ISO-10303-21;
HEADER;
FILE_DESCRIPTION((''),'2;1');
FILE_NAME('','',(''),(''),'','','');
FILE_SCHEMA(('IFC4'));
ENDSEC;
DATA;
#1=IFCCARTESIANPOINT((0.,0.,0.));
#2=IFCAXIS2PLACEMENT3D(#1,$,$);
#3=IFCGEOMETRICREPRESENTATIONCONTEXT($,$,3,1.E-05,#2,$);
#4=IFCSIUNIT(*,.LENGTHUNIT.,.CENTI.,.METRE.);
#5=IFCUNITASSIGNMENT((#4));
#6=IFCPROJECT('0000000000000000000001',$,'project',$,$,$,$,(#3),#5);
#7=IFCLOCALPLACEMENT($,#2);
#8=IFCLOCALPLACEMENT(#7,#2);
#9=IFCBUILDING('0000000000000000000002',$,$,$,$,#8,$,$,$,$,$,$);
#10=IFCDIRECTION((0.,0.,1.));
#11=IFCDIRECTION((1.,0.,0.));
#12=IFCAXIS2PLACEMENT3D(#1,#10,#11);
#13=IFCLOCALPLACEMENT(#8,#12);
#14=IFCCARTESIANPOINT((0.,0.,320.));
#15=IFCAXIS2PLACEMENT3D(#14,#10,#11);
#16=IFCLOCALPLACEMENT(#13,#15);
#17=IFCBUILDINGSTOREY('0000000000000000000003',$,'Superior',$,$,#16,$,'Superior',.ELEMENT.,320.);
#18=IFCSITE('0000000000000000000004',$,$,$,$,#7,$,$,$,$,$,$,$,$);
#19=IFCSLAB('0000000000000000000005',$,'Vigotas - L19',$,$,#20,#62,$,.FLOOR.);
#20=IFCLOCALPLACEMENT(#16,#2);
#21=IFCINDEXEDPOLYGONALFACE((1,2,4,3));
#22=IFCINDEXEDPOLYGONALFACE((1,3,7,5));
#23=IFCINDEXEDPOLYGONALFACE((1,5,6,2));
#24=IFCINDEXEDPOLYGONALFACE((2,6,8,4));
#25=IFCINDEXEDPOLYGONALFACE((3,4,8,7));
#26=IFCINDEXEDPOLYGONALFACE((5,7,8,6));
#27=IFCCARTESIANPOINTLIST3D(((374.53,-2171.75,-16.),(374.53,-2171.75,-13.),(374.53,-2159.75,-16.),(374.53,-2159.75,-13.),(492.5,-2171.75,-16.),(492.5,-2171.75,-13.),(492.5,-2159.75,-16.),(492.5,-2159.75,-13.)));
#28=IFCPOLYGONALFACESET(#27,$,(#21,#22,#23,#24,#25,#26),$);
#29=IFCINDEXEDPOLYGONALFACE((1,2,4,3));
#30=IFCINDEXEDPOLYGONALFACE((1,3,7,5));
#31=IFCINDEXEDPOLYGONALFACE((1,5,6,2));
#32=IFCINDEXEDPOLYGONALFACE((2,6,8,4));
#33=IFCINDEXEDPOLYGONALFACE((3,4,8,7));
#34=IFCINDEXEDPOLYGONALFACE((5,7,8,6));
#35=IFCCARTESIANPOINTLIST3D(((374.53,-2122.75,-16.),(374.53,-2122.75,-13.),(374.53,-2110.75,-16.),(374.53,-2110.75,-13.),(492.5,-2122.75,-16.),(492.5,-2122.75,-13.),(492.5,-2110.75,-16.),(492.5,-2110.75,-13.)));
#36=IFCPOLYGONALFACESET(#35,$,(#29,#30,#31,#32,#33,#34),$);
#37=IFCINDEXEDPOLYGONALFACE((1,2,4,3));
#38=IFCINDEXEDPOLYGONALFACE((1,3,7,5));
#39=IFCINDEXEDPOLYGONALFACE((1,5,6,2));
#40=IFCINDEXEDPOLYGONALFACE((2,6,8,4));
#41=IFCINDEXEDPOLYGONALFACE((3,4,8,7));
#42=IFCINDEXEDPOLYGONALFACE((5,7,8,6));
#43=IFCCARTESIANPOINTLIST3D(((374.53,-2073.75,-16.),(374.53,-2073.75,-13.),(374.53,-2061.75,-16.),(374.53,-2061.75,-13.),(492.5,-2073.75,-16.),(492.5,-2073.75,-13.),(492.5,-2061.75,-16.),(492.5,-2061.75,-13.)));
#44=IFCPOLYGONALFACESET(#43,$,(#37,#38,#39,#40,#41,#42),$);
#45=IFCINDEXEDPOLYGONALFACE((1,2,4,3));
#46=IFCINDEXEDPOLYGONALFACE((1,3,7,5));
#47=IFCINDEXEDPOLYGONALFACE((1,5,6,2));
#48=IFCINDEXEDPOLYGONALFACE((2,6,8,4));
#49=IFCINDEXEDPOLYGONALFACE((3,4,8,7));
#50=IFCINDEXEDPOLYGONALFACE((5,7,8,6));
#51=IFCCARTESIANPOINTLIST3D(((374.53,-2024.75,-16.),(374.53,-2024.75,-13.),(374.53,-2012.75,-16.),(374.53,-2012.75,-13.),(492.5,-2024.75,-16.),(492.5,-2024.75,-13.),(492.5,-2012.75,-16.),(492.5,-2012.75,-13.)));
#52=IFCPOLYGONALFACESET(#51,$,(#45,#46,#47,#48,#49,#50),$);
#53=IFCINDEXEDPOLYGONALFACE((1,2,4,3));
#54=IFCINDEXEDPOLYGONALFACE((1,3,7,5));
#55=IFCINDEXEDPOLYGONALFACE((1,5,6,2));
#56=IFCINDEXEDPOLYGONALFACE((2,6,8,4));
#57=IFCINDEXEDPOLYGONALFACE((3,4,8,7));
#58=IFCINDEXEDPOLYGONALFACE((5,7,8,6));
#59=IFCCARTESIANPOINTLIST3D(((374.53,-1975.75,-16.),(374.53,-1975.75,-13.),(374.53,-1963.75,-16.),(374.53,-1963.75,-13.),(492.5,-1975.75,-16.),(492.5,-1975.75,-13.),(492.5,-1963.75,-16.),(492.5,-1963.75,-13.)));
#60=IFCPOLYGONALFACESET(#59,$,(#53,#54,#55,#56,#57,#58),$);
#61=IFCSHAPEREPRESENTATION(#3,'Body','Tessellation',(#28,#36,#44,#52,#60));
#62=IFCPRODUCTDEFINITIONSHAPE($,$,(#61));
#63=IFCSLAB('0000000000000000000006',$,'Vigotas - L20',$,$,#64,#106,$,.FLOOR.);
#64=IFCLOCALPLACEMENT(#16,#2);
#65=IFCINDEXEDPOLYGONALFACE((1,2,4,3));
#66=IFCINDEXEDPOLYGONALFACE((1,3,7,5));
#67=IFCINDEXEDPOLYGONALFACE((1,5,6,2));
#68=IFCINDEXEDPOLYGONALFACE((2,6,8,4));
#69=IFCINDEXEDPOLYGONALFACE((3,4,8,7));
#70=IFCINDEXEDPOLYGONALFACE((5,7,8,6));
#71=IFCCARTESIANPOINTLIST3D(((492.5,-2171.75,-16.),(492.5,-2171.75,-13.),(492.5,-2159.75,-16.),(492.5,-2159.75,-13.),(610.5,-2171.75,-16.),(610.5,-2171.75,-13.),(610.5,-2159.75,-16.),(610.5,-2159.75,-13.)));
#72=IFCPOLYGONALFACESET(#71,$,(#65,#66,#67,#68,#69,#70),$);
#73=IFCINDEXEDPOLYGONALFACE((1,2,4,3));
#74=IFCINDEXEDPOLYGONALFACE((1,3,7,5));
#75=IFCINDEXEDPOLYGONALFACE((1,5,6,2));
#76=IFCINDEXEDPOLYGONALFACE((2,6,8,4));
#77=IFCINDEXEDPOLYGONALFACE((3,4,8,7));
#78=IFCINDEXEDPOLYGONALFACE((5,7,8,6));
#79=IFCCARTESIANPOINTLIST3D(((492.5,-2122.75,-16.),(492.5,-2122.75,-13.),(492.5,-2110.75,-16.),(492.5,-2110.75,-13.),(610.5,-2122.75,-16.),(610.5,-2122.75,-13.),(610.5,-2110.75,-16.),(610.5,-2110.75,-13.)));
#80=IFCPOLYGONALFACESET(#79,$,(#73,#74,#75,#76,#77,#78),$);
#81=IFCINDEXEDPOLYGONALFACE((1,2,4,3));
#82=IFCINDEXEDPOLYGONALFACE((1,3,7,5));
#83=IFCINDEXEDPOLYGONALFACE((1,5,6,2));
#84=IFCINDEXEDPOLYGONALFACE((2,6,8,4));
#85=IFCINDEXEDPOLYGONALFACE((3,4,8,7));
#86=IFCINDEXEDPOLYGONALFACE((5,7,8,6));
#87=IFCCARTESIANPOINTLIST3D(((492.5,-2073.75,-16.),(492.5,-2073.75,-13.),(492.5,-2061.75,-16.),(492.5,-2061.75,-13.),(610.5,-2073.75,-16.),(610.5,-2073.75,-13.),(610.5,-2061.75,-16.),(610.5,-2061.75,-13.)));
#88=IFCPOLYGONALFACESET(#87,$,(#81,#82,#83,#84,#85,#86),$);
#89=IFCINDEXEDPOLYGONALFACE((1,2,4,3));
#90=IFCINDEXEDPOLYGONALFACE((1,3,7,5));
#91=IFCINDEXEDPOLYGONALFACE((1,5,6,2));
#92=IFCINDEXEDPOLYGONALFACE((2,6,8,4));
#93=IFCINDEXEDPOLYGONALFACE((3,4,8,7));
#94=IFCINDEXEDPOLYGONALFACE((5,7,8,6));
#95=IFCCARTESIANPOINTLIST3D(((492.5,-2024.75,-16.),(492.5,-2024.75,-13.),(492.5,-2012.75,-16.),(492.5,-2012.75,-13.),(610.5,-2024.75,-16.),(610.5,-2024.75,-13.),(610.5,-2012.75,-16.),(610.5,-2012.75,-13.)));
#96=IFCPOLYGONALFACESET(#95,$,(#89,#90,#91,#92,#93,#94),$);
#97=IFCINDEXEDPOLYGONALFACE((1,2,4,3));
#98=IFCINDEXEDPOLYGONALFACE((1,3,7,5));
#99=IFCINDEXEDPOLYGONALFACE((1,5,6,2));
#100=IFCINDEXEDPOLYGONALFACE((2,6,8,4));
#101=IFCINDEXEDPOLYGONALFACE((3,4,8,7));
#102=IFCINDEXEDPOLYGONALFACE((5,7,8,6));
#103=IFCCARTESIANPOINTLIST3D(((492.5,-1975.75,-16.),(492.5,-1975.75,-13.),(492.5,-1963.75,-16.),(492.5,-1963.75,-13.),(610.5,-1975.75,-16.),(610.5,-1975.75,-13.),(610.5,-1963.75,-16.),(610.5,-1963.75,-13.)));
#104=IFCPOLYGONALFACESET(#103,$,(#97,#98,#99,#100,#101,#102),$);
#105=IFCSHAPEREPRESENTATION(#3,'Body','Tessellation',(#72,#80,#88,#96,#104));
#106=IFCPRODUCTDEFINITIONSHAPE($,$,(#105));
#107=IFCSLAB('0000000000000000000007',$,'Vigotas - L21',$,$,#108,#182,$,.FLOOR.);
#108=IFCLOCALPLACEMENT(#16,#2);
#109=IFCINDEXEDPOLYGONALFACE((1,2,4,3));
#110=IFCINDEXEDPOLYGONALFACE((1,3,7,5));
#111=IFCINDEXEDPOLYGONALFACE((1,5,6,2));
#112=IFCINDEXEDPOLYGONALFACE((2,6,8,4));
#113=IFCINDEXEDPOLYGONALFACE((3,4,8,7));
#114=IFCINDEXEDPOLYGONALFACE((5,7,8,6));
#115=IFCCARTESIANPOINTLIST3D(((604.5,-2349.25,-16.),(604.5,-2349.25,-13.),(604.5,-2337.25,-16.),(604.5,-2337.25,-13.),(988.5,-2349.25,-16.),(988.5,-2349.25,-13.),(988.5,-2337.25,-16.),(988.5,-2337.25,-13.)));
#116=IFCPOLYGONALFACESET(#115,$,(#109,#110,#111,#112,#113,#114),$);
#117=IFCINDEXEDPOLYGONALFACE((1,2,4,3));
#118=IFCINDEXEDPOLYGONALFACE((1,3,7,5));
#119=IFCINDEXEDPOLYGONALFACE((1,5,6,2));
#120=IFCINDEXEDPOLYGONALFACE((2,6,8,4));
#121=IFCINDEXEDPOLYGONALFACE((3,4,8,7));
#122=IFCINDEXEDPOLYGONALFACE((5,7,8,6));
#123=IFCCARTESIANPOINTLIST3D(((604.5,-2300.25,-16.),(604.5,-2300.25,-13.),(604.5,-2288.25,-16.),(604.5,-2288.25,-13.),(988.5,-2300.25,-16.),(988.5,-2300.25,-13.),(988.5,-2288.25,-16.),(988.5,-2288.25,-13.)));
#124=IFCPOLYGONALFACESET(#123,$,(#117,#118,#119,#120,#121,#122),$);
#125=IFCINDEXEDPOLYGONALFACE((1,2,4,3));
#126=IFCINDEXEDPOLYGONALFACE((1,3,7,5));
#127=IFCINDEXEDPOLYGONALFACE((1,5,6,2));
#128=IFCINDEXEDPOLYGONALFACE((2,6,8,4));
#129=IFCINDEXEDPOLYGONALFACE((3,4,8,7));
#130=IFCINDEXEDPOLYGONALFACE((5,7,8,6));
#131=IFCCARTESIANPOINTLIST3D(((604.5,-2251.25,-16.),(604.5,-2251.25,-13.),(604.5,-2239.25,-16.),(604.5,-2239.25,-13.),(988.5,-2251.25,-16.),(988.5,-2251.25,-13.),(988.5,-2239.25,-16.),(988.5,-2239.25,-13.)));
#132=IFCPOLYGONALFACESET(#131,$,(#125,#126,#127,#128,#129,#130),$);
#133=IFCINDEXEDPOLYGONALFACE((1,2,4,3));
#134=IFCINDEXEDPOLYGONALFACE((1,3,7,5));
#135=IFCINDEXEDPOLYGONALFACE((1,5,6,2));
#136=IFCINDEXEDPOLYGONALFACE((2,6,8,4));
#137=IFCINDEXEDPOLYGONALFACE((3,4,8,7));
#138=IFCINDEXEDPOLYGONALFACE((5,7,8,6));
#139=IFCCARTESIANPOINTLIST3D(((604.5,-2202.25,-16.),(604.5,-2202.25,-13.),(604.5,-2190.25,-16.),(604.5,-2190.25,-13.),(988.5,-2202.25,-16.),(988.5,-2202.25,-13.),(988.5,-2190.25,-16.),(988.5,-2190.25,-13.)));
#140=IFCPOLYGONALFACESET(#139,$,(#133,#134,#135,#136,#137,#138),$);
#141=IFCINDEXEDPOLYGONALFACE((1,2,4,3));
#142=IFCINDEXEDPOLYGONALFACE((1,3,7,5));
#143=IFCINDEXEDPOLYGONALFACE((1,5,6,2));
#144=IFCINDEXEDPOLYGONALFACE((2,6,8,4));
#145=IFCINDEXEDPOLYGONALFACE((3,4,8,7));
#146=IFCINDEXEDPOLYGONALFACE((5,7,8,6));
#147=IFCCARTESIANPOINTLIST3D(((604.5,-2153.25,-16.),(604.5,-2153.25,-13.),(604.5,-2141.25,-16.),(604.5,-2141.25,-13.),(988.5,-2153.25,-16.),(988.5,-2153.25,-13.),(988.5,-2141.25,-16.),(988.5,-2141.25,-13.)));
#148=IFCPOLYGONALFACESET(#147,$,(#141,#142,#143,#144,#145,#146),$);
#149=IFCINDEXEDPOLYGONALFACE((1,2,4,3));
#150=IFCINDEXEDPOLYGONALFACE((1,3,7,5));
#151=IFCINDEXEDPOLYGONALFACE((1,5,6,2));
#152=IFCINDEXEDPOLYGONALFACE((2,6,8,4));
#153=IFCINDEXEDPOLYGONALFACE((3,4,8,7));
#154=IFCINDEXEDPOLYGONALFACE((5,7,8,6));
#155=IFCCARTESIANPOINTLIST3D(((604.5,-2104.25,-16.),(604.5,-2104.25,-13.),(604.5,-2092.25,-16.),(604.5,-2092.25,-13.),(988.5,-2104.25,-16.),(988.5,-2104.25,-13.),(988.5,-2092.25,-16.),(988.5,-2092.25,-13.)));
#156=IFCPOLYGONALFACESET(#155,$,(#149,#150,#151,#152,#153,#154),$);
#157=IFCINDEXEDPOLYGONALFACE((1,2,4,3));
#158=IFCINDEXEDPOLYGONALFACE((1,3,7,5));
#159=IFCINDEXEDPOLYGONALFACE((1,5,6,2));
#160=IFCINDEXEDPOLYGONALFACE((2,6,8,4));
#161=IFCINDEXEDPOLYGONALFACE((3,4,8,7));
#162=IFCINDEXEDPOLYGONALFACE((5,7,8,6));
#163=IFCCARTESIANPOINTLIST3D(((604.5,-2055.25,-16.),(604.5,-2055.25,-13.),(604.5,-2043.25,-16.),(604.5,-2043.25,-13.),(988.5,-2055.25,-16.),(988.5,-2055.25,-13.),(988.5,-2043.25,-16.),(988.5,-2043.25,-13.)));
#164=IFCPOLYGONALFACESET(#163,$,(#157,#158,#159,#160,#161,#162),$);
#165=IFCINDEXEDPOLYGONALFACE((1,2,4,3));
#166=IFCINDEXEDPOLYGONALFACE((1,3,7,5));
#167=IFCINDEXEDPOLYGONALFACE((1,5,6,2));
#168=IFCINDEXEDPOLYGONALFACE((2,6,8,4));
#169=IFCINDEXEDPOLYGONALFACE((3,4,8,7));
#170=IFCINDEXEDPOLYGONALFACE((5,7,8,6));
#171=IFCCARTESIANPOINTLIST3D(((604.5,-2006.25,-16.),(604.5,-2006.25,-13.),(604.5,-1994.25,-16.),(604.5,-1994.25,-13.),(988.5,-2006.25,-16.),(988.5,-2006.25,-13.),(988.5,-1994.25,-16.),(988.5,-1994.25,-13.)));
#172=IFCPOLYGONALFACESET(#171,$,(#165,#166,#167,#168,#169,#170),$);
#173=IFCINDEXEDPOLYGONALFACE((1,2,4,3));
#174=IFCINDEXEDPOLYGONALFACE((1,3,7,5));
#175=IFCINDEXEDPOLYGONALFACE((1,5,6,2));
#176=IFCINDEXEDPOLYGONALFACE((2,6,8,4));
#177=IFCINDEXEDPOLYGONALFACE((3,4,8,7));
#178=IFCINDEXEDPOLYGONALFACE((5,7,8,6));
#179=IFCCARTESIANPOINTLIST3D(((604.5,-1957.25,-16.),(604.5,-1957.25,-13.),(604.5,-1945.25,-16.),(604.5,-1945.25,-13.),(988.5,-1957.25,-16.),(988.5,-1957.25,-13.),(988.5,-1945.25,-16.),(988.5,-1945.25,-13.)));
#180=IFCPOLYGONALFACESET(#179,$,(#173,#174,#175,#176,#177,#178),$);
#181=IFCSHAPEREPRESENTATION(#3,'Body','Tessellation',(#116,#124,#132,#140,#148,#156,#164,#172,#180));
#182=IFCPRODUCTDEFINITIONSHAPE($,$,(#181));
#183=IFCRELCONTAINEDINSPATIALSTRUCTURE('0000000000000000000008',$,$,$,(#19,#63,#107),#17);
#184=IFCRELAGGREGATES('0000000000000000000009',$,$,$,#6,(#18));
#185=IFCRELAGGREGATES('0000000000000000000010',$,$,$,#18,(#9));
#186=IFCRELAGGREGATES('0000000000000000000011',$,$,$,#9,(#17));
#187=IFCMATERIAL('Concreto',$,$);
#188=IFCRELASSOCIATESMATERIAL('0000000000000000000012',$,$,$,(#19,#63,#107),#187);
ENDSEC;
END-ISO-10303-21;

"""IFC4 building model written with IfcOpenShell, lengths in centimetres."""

from ifc_helpers import new_model, si_unit, frame, origin, origin_with_axes, place, context, project, spatial, polyline, outline, extrude, material, element, save


model = new_model("IFC4")

# Units and contexts
context_of_model = context(None, 3, precision=1e-05, world=origin())
ifc_project = project(units=[si_unit("LENGTHUNIT", "METRE", prefix="CENTI")], contexts=[context_of_model])

# Site, building, storey
site_placement = place(None, origin())
site = spatial("IfcSite", under=ifc_project, at=site_placement)
building_placement = place(site_placement, origin())
building = spatial("IfcBuilding", under=site, at=building_placement)
placement = place(building_placement, origin_with_axes())
storey_placement = place(placement, frame((0.0, 0.0, 320.0), z_axis=(0.0, 0.0, 1.0), x_axis=(1.0, 0.0, 0.0)))
storey = spatial("IfcBuildingStorey", under=building, at=storey_placement, Name="Superior", LongName="Superior", CompositionType="ELEMENT", Elevation=320.0)

# Shared definitions
ifc_material = material(Name="Concreto")

# Slabs
slab_1_placement = place(storey_placement, frame((433.51, -2067.75, -13.0), z_axis=(0.0, 0.0, 1.0), x_axis=(1.0, 0.0, 0.0)))
element("IfcSlab", 1, at=slab_1_placement, inside=storey, material=ifc_material, Name="Vigotas - L19", PredefinedType="FLOOR", context=context_of_model, shape_type="SolidModel", body=[
    extrude(outline(polyline([(6.0, 1.5), (-6.0, 1.5), (-6.0, -1.5), (6.0, -1.5), (6.0, 1.5), (6.0, 1.5)])), frame((-58.98, -98.0, -1.5), z_axis=(1.0, 0.0, 0.0), x_axis=(0.0, -1.0, 0.0)), (0.0, 0.0, 1.0), 117.97),
    extrude(outline(polyline([(6.0, 1.5), (-6.0, 1.5), (-6.0, -1.5), (6.0, -1.5), (6.0, 1.5), (6.0, 1.5)])), frame((-58.98, -49.0, -1.5), z_axis=(1.0, 0.0, 0.0), x_axis=(0.0, -1.0, 0.0)), (0.0, 0.0, 1.0), 117.97),
    extrude(outline(polyline([(6.0, 1.5), (-6.0, 1.5), (-6.0, -1.5), (6.0, -1.5), (6.0, 1.5), (6.0, 1.5)])), frame((-58.98, 0.0, -1.5), z_axis=(1.0, 0.0, 0.0), x_axis=(0.0, -1.0, 0.0)), (0.0, 0.0, 1.0), 117.97),
    extrude(outline(polyline([(6.0, 1.5), (-6.0, 1.5), (-6.0, -1.5), (6.0, -1.5), (6.0, 1.5), (6.0, 1.5)])), frame((-58.98, 49.0, -1.5), z_axis=(1.0, 0.0, 0.0), x_axis=(0.0, -1.0, 0.0)), (0.0, 0.0, 1.0), 117.97),
    extrude(outline(polyline([(6.0, 1.5), (-6.0, 1.5), (-6.0, -1.5), (6.0, -1.5), (6.0, 1.5), (6.0, 1.5)])), frame((-58.98, 98.0, -1.5), z_axis=(1.0, 0.0, 0.0), x_axis=(0.0, -1.0, 0.0)), (0.0, 0.0, 1.0), 117.97),
])
slab_2_placement = place(storey_placement, frame((551.5, -2067.75, -13.0), z_axis=(0.0, 0.0, 1.0), x_axis=(1.0, 0.0, 0.0)))
element("IfcSlab", 2, at=slab_2_placement, inside=storey, material=ifc_material, Name="Vigotas - L20", PredefinedType="FLOOR", context=context_of_model, shape_type="SolidModel", body=[
    extrude(outline(polyline([(6.0, 1.5), (-6.0, 1.5), (-6.0, -1.5), (6.0, -1.5), (6.0, 1.5), (6.0, 1.5)])), frame((-59.0, -98.0, -1.5), z_axis=(1.0, 0.0, 0.0), x_axis=(0.0, -1.0, 0.0)), (0.0, 0.0, 1.0), 118.0),
    extrude(outline(polyline([(6.0, 1.5), (-6.0, 1.5), (-6.0, -1.5), (6.0, -1.5), (6.0, 1.5), (6.0, 1.5)])), frame((-59.0, -49.0, -1.5), z_axis=(1.0, 0.0, 0.0), x_axis=(0.0, -1.0, 0.0)), (0.0, 0.0, 1.0), 118.0),
    extrude(outline(polyline([(6.0, 1.5), (-6.0, 1.5), (-6.0, -1.5), (6.0, -1.5), (6.0, 1.5), (6.0, 1.5)])), frame((-59.0, 0.0, -1.5), z_axis=(1.0, 0.0, 0.0), x_axis=(0.0, -1.0, 0.0)), (0.0, 0.0, 1.0), 118.0),
    extrude(outline(polyline([(6.0, 1.5), (-6.0, 1.5), (-6.0, -1.5), (6.0, -1.5), (6.0, 1.5), (6.0, 1.5)])), frame((-59.0, 49.0, -1.5), z_axis=(1.0, 0.0, 0.0), x_axis=(0.0, -1.0, 0.0)), (0.0, 0.0, 1.0), 118.0),
    extrude(outline(polyline([(6.0, 1.5), (-6.0, 1.5), (-6.0, -1.5), (6.0, -1.5), (6.0, 1.5), (6.0, 1.5)])), frame((-59.0, 98.0, -1.5), z_axis=(1.0, 0.0, 0.0), x_axis=(0.0, -1.0, 0.0)), (0.0, 0.0, 1.0), 118.0),
])
slab_3_placement = place(storey_placement, frame((796.5, -2147.25, -13.0), z_axis=(0.0, 0.0, 1.0), x_axis=(1.0, 0.0, 0.0)))
element("IfcSlab", 3, at=slab_3_placement, inside=storey, material=ifc_material, Name="Vigotas - L21", PredefinedType="FLOOR", context=context_of_model, shape_type="SolidModel", body=[
    extrude(outline(polyline([(6.0, 1.5), (-6.0, 1.5), (-6.0, -1.5), (6.0, -1.5), (6.0, 1.5), (6.0, 1.5)])), frame((-192.0, -196.0, -1.5), z_axis=(1.0, 0.0, 0.0), x_axis=(0.0, -1.0, 0.0)), (0.0, 0.0, 1.0), 384.0),
    extrude(outline(polyline([(6.0, 1.5), (-6.0, 1.5), (-6.0, -1.5), (6.0, -1.5), (6.0, 1.5), (6.0, 1.5)])), frame((-192.0, -147.0, -1.5), z_axis=(1.0, 0.0, 0.0), x_axis=(0.0, -1.0, 0.0)), (0.0, 0.0, 1.0), 384.0),
    extrude(outline(polyline([(6.0, 1.5), (-6.0, 1.5), (-6.0, -1.5), (6.0, -1.5), (6.0, 1.5), (6.0, 1.5)])), frame((-192.0, -98.0, -1.5), z_axis=(1.0, 0.0, 0.0), x_axis=(0.0, -1.0, 0.0)), (0.0, 0.0, 1.0), 384.0),
    extrude(outline(polyline([(6.0, 1.5), (-6.0, 1.5), (-6.0, -1.5), (6.0, -1.5), (6.0, 1.5), (6.0, 1.5)])), frame((-192.0, -49.0, -1.5), z_axis=(1.0, 0.0, 0.0), x_axis=(0.0, -1.0, 0.0)), (0.0, 0.0, 1.0), 384.0),
    extrude(outline(polyline([(6.0, 1.5), (-6.0, 1.5), (-6.0, -1.5), (6.0, -1.5), (6.0, 1.5), (6.0, 1.5)])), frame((-192.0, 0.0, -1.5), z_axis=(1.0, 0.0, 0.0), x_axis=(0.0, -1.0, 0.0)), (0.0, 0.0, 1.0), 384.0),
    extrude(outline(polyline([(6.0, 1.5), (-6.0, 1.5), (-6.0, -1.5), (6.0, -1.5), (6.0, 1.5), (6.0, 1.5)])), frame((-192.0, 49.0, -1.5), z_axis=(1.0, 0.0, 0.0), x_axis=(0.0, -1.0, 0.0)), (0.0, 0.0, 1.0), 384.0),
    extrude(outline(polyline([(6.0, 1.5), (-6.0, 1.5), (-6.0, -1.5), (6.0, -1.5), (6.0, 1.5), (6.0, 1.5)])), frame((-192.0, 98.0, -1.5), z_axis=(1.0, 0.0, 0.0), x_axis=(0.0, -1.0, 0.0)), (0.0, 0.0, 1.0), 384.0),
    extrude(outline(polyline([(6.0, 1.5), (-6.0, 1.5), (-6.0, -1.5), (6.0, -1.5), (6.0, 1.5), (6.0, 1.5)])), frame((-192.0, 147.0, -1.5), z_axis=(1.0, 0.0, 0.0), x_axis=(0.0, -1.0, 0.0)), (0.0, 0.0, 1.0), 384.0),
    extrude(outline(polyline([(6.0, 1.5), (-6.0, 1.5), (-6.0, -1.5), (6.0, -1.5), (6.0, 1.5), (6.0, 1.5)])), frame((-192.0, 196.0, -1.5), z_axis=(1.0, 0.0, 0.0), x_axis=(0.0, -1.0, 0.0)), (0.0, 0.0, 1.0), 384.0),
])

save(model, "model.ifc")
